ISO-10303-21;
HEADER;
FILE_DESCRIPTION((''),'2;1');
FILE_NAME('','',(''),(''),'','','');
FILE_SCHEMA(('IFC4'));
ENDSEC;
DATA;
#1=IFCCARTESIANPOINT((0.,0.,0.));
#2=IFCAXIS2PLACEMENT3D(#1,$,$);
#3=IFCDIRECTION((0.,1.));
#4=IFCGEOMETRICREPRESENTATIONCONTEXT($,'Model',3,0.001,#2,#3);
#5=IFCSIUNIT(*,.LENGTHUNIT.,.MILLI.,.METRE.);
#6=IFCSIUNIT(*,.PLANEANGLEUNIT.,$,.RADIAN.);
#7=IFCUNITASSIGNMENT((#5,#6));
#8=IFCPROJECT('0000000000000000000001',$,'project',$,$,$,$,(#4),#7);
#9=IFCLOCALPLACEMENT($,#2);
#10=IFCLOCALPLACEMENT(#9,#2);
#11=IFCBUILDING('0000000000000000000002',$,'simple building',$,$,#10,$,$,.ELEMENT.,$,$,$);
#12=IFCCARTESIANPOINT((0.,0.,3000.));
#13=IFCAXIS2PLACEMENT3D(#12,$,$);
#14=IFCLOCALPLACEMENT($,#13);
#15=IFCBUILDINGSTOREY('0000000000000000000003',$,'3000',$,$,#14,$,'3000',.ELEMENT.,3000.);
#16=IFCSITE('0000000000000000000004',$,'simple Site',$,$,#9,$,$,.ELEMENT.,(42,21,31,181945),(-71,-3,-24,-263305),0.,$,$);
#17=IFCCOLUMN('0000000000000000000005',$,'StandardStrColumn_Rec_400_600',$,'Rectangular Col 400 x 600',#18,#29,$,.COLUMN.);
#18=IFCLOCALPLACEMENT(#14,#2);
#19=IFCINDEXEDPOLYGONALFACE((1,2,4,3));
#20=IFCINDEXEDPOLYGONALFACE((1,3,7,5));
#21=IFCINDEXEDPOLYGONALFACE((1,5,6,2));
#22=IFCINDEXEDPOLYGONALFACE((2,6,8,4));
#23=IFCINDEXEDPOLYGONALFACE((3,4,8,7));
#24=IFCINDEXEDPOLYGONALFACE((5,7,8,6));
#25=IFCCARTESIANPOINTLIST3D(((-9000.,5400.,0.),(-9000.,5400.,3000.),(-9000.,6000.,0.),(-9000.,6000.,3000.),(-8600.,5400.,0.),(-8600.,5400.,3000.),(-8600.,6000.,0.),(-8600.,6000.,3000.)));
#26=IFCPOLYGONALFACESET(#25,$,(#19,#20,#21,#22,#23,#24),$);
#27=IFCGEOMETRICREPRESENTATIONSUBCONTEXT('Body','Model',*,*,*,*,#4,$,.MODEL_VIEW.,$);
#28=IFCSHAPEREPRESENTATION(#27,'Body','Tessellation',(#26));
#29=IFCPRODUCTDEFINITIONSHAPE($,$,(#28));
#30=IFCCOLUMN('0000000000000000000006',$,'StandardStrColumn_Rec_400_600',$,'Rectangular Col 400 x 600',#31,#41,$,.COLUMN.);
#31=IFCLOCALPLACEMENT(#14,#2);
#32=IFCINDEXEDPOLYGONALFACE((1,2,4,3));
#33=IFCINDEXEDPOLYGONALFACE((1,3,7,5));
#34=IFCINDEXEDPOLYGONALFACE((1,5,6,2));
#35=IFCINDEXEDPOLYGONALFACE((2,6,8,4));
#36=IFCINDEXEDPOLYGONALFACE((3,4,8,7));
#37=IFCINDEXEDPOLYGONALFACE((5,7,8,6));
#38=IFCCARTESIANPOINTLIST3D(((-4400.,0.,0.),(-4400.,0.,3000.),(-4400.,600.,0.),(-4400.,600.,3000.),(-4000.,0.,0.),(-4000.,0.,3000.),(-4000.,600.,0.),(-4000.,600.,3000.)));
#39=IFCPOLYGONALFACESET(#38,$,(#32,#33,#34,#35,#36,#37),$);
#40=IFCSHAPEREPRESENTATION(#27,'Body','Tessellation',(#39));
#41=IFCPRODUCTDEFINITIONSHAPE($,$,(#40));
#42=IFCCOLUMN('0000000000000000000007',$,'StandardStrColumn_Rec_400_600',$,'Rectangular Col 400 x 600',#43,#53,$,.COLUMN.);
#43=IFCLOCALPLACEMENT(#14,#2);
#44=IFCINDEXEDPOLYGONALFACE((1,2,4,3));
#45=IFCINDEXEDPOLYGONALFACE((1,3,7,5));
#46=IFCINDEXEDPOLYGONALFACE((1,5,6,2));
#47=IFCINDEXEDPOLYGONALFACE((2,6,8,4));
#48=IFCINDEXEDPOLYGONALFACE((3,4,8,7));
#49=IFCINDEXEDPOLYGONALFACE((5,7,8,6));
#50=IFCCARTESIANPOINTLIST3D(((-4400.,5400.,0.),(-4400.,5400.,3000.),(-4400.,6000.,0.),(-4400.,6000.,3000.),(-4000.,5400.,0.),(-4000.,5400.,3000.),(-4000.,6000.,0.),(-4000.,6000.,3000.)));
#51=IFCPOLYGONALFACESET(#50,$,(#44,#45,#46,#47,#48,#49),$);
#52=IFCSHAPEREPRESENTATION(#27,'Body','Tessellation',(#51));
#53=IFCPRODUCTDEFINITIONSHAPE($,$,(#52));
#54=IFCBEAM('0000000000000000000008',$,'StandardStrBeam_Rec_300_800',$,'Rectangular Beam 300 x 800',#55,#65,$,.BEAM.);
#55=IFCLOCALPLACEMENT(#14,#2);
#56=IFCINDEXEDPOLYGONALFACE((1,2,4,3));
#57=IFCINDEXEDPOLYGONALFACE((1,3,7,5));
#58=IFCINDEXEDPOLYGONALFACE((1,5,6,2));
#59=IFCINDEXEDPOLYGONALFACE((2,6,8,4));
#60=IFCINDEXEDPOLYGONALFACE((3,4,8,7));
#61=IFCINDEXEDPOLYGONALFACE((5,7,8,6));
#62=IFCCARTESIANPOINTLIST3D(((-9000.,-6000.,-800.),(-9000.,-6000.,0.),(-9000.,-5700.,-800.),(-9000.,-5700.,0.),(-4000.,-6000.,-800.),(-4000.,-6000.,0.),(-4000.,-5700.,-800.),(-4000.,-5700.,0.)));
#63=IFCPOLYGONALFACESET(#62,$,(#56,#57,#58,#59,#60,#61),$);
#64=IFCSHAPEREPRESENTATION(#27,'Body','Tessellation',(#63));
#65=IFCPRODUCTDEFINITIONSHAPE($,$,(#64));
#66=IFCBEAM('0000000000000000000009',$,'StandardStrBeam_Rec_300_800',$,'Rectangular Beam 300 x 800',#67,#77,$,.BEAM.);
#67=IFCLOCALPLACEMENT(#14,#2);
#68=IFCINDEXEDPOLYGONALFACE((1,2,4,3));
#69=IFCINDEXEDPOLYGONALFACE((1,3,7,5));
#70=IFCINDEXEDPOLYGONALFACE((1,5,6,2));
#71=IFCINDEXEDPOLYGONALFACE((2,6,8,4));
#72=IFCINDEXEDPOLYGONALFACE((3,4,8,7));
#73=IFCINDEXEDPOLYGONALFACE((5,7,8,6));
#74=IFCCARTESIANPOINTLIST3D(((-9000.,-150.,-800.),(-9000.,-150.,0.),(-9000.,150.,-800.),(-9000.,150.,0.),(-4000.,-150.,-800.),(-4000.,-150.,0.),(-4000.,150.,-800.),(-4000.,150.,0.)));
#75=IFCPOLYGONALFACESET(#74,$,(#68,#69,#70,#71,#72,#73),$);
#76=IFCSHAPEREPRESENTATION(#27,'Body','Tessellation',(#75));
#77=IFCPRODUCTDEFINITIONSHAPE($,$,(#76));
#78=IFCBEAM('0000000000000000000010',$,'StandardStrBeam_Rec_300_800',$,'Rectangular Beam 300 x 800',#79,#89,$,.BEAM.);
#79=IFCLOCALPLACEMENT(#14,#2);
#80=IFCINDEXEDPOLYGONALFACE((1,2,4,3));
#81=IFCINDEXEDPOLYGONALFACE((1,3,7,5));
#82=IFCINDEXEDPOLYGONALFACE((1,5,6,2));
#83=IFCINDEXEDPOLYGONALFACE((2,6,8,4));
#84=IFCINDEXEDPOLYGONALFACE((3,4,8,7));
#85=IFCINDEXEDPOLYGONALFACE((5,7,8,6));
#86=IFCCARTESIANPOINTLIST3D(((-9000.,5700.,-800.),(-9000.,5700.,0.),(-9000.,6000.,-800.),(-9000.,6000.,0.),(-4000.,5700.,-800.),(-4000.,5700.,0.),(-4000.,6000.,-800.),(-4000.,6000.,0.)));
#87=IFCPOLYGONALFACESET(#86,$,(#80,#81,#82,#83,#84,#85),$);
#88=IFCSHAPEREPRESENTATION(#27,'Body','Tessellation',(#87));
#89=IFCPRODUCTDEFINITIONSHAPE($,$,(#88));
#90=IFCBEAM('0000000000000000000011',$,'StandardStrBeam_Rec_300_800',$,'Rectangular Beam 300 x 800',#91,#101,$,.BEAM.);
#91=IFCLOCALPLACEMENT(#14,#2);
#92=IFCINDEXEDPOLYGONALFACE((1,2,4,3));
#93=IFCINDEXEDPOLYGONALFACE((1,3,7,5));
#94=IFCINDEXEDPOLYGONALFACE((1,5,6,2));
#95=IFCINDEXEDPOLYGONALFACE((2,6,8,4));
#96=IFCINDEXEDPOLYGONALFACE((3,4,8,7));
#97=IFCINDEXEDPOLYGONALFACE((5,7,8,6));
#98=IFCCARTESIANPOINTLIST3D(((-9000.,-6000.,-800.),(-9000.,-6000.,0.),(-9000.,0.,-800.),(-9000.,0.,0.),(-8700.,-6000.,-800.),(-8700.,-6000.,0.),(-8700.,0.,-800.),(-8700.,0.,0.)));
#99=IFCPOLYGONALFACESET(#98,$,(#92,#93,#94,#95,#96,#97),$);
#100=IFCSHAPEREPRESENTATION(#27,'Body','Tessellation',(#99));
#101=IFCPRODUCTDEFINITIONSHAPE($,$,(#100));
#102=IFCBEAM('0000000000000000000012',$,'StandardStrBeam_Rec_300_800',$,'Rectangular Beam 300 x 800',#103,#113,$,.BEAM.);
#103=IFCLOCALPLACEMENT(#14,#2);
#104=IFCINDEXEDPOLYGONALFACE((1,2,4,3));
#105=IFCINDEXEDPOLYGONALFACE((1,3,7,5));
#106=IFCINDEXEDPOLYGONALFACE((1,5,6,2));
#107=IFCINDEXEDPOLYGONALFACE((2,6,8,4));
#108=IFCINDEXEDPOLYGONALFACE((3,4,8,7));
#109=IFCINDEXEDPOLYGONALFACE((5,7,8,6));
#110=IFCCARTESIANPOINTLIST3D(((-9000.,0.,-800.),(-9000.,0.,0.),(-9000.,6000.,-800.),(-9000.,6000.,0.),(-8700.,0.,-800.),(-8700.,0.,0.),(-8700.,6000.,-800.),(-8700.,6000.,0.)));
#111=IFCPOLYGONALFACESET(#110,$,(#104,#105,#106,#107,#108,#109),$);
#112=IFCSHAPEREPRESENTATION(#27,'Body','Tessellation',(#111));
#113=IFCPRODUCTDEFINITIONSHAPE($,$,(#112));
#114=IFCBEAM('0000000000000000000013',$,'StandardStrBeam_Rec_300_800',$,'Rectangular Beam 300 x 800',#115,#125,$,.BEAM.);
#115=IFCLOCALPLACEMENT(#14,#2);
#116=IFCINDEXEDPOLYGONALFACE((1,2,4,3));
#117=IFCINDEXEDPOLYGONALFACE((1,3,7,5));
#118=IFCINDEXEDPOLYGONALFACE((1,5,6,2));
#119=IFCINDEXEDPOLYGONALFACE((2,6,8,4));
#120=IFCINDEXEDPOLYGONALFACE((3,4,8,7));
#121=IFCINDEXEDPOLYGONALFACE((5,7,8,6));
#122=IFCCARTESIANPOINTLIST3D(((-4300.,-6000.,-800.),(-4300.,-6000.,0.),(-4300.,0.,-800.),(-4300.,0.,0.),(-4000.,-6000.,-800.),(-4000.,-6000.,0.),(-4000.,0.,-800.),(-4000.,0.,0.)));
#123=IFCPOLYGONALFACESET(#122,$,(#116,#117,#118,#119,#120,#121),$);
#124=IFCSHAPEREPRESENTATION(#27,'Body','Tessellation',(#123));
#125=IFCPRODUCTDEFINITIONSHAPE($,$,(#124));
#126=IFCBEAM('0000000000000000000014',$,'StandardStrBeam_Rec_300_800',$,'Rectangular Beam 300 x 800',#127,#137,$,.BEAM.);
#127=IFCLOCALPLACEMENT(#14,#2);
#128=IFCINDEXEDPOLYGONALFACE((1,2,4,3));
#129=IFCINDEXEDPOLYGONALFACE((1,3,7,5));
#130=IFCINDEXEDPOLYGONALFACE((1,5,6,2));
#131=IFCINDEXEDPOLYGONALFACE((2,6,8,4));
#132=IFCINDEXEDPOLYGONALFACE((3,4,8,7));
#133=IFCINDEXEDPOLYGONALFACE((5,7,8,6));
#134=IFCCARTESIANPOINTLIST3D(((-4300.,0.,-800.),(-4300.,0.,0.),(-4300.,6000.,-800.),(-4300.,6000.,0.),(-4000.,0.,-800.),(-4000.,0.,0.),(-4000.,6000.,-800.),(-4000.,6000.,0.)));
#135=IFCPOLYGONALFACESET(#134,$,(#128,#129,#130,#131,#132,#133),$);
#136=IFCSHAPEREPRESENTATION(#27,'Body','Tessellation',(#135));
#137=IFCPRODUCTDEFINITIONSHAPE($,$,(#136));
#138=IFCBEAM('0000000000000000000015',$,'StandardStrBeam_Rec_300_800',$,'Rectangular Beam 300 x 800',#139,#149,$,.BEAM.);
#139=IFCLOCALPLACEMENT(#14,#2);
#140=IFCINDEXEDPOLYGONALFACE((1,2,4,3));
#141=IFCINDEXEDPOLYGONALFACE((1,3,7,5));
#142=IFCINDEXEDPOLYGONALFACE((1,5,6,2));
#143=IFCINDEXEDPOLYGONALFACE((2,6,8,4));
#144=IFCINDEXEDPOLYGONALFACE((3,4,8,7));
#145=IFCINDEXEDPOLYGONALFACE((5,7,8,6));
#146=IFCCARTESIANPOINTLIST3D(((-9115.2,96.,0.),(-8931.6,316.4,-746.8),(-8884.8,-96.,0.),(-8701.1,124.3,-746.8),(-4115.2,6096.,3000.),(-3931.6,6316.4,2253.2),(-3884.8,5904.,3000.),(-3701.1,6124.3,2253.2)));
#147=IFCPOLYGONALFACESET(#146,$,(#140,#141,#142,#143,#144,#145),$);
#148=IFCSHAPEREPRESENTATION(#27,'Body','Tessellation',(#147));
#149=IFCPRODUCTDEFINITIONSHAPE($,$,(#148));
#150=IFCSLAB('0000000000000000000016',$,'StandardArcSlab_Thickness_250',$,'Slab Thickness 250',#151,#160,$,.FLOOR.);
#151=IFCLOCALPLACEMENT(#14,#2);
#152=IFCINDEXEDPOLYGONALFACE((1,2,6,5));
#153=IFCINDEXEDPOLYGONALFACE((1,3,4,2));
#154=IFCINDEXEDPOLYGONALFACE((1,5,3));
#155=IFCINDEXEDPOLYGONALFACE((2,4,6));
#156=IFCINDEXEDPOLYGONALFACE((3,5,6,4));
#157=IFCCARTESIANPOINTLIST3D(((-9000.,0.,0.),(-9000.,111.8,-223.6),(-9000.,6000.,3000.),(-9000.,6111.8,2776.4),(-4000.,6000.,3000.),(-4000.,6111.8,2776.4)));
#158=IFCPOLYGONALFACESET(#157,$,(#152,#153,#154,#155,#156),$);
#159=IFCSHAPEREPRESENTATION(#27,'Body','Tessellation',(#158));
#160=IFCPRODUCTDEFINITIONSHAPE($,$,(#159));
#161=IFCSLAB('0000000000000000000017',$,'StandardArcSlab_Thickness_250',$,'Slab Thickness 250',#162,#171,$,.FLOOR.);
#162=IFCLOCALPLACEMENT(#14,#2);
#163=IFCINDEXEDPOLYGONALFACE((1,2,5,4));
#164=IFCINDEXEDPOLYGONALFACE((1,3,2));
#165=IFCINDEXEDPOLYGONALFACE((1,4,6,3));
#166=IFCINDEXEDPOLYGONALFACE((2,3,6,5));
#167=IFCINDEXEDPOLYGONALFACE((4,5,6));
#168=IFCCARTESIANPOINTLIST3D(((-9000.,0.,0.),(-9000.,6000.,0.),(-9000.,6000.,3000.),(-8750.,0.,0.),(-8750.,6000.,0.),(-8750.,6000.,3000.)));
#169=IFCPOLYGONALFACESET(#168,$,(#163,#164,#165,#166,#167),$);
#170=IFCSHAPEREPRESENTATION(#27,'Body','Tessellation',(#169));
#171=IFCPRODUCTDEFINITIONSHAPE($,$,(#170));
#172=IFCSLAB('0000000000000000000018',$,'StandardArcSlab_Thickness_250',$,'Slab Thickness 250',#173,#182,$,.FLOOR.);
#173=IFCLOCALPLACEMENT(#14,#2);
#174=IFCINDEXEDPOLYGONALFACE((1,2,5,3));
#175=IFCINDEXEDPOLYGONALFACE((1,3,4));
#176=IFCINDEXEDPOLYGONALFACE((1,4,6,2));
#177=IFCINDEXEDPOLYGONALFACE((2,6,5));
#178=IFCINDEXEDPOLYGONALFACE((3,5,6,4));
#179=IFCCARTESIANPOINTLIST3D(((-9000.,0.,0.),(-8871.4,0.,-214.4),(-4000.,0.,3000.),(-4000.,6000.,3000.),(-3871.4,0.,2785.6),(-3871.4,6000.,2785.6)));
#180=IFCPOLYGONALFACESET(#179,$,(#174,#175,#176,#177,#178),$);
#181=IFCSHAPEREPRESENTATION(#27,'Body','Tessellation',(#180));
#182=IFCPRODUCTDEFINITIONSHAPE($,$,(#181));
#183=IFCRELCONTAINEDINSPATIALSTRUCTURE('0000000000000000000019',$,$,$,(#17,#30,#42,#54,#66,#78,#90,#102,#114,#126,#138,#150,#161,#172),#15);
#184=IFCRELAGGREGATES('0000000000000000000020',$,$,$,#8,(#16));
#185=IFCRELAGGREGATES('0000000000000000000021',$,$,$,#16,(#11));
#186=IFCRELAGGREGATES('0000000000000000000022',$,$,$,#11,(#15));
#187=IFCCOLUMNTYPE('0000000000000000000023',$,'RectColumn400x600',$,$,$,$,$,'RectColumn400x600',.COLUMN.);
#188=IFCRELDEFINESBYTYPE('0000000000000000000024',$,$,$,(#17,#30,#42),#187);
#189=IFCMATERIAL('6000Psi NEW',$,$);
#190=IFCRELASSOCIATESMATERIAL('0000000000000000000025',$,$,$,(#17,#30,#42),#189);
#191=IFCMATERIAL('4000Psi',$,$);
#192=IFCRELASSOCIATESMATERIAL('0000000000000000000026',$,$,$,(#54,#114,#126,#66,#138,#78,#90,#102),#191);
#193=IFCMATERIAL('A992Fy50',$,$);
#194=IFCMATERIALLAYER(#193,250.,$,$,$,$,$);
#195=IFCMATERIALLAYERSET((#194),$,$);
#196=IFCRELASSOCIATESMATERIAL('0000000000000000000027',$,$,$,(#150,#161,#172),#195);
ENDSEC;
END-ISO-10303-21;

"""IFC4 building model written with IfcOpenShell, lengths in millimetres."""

from ifc_helpers import new_model, si_unit, direction, frame, origin, origin_with_axes, origin_2d_with_axis, place, context, subcontext, project, spatial, polyline, rectangle, outline, extrude, material, layer, layer_set, layer_usage, material_profile, profile_set, profile_usage, type_object, element, save


model = new_model("IFC4")

# Units and contexts
model_context = context("Model", 3, precision=0.001, world=origin(), true_north=direction((0.0, 1.0)))
body_context = subcontext(model_context, "Body", "Model", "MODEL_VIEW")
ifc_project = project(units=[si_unit("LENGTHUNIT", "METRE", prefix="MILLI"), si_unit("PLANEANGLEUNIT", "RADIAN")], contexts=[model_context])

# Site, building, storey
site_placement = place(None, origin())
site = spatial("IfcSite", under=ifc_project, at=site_placement, Name="simple Site", CompositionType="ELEMENT", RefLatitude=(42, 21, 31, 181945), RefLongitude=(-71, -3, -24, -263305), RefElevation=0.0)
building_placement = place(site_placement, origin())
building = spatial("IfcBuilding", under=site, at=building_placement, Name="simple building", CompositionType="ELEMENT")
storey_placement = place(None, frame((0.0, 0.0, 3000.0)))
storey = spatial("IfcBuildingStorey", under=building, at=storey_placement, Name="3000", LongName="3000", CompositionType="ELEMENT", Elevation=3000.0)

# Columns
ifc_material_1 = material(Name="6000Psi NEW")
ifc_material_profile_1 = material_profile(ifc_material_1, rectangle(XDim=400.0, YDim=600.0, at=origin_2d_with_axis()))
ifc_profile_set_1 = profile_set([ifc_material_profile_1])
ifc_profile_usage_1 = profile_usage(ifc_profile_set_1, cardinal=1)
column_type = type_object("IfcColumnType", Name="RectColumn400x600", ElementType="RectColumn400x600", PredefinedType="COLUMN")
column_1_placement = place(None, frame((-8800.0, 5700.0, 3000.0), z_axis=(0.0, 0.0, 1.0), x_axis=(1.0, 0.0, 0.0)))
element("IfcColumn", 1, at=column_1_placement, inside=storey, type_object=column_type, material=ifc_profile_usage_1, Name="StandardStrColumn_Rec_400_600", ObjectType="Rectangular Col 400 x 600", PredefinedType="COLUMN", context=body_context, shape_type="SweptSolid", body=[
    extrude(rectangle(XDim=400.0, YDim=600.0, at=origin_2d_with_axis()), origin_with_axes(), (0.0, 0.0, 1.0), 3000.0),
])
ifc_profile_usage_2 = profile_usage(ifc_profile_set_1, cardinal=9)
column_2_placement = place(None, frame((-4200.0, 300.0, 3000.0), z_axis=(0.0, 0.0, 1.0), x_axis=(1.0, 0.0, 0.0)))
element("IfcColumn", 2, at=column_2_placement, inside=storey, type_object=column_type, material=ifc_profile_usage_2, Name="StandardStrColumn_Rec_400_600", ObjectType="Rectangular Col 400 x 600", PredefinedType="COLUMN", context=body_context, shape_type="SweptSolid", body=[
    extrude(rectangle(XDim=400.0, YDim=600.0, at=origin_2d_with_axis()), origin_with_axes(), (0.0, 0.0, 1.0), 3000.0),
])
ifc_profile_usage_3 = profile_usage(ifc_profile_set_1, cardinal=3)
column_3_placement = place(None, frame((-4200.0, 5700.0, 3000.0), z_axis=(0.0, 0.0, 1.0), x_axis=(1.0, 0.0, 0.0)))
element("IfcColumn", 3, at=column_3_placement, inside=storey, type_object=column_type, material=ifc_profile_usage_3, Name="StandardStrColumn_Rec_400_600", ObjectType="Rectangular Col 400 x 600", PredefinedType="COLUMN", context=body_context, shape_type="SweptSolid", body=[
    extrude(rectangle(XDim=400.0, YDim=600.0, at=origin_2d_with_axis()), origin_with_axes(), (0.0, 0.0, 1.0), 3000.0),
])

# Beams
ifc_material_2 = material(Name="4000Psi")
ifc_material_profile_2 = material_profile(ifc_material_2, rectangle(XDim=300.0, YDim=800.0, at=origin_2d_with_axis()))
ifc_profile_set_2 = profile_set([ifc_material_profile_2])
ifc_profile_usage_4 = profile_usage(ifc_profile_set_2, cardinal=9)
beam_1_placement = place(None, frame((-9000.0, -5850.0, 2600.0), z_axis=(1.0, 0.0, 0.0), x_axis=(0.0, -1.0, 0.0)))
element("IfcBeam", 4, at=beam_1_placement, inside=storey, material=ifc_profile_usage_4, Name="StandardStrBeam_Rec_300_800", ObjectType="Rectangular Beam 300 x 800", PredefinedType="BEAM", context=body_context, shape_type="SweptSolid", body=[
    extrude(rectangle(XDim=300.0, YDim=800.0, at=origin_2d_with_axis()), origin_with_axes(), (0.0, 0.0, 1.0), 5000.0),
])
ifc_profile_usage_5 = profile_usage(ifc_profile_set_2, cardinal=8)
beam_2_placement = place(None, frame((-9000.0, 0.0, 2600.0), z_axis=(1.0, 0.0, 0.0), x_axis=(0.0, -1.0, 0.0)))
element("IfcBeam", 5, at=beam_2_placement, inside=storey, material=ifc_profile_usage_5, Name="StandardStrBeam_Rec_300_800", ObjectType="Rectangular Beam 300 x 800", PredefinedType="BEAM", context=body_context, shape_type="SweptSolid", body=[
    extrude(rectangle(XDim=300.0, YDim=800.0, at=origin_2d_with_axis()), origin_with_axes(), (0.0, 0.0, 1.0), 5000.0),
])
ifc_profile_usage_6 = profile_usage(ifc_profile_set_2, cardinal=7)
beam_3_placement = place(None, frame((-9000.0, 5850.0, 2600.0), z_axis=(1.0, 0.0, 0.0), x_axis=(0.0, -1.0, 0.0)))
element("IfcBeam", 6, at=beam_3_placement, inside=storey, material=ifc_profile_usage_6, Name="StandardStrBeam_Rec_300_800", ObjectType="Rectangular Beam 300 x 800", PredefinedType="BEAM", context=body_context, shape_type="SweptSolid", body=[
    extrude(rectangle(XDim=300.0, YDim=800.0, at=origin_2d_with_axis()), origin_with_axes(), (0.0, 0.0, 1.0), 5000.0),
])
for number, where, z_axis, x_axis, name in (
    (7, (-8850.0, -6000.0, 2600.0), (0.0, 1.0, 0.0), (1.0, 0.0, 0.0), "StandardStrBeam_Rec_300_800"),
    (8, (-8850.0, 0.0, 2600.0), (0.0, 1.0, 0.0), (1.0, 0.0, 0.0), "StandardStrBeam_Rec_300_800"),
):
    element("IfcBeam", number, at=place(None, frame(where, z_axis=z_axis, x_axis=x_axis)), inside=storey, material=ifc_profile_usage_6, Name=name, ObjectType="Rectangular Beam 300 x 800", PredefinedType="BEAM", context=body_context, shape_type="SweptSolid", body=[
        extrude(rectangle(XDim=300.0, YDim=800.0, at=origin_2d_with_axis()), origin_with_axes(), (0.0, 0.0, 1.0), 6000.0),
    ])
for number, where, z_axis, x_axis, name in (
    (9, (-4150.0, -6000.0, 2600.0), (0.0, 1.0, 0.0), (1.0, 0.0, 0.0), "StandardStrBeam_Rec_300_800"),
    (10, (-4150.0, 0.0, 2600.0), (0.0, 1.0, 0.0), (1.0, 0.0, 0.0), "StandardStrBeam_Rec_300_800"),
):
    element("IfcBeam", number, at=place(None, frame(where, z_axis=z_axis, x_axis=x_axis)), inside=storey, material=ifc_profile_usage_4, Name=name, ObjectType="Rectangular Beam 300 x 800", PredefinedType="BEAM", context=body_context, shape_type="SweptSolid", body=[
        extrude(rectangle(XDim=300.0, YDim=800.0, at=origin_2d_with_axis()), origin_with_axes(), (0.0, 0.0, 1.0), 6000.0),
    ])
beam_4_placement = place(None, frame((-8908.2, 110.2, 2626.6), z_axis=(0.597614, 0.717137, 0.358569), x_axis=(0.768221, -0.640184, 0.0)))
element("IfcBeam", 11, at=beam_4_placement, inside=storey, material=ifc_profile_usage_5, Name="StandardStrBeam_Rec_300_800", ObjectType="Rectangular Beam 300 x 800", PredefinedType="BEAM", context=body_context, shape_type="SweptSolid", body=[
    extrude(rectangle(XDim=300.0, YDim=800.0, at=origin_2d_with_axis()), origin_with_axes(), (0.0, 0.0, 1.0), 8366.6),
])

# Slabs
ifc_material_3 = material(Name="A992Fy50")
ifc_layer_1 = layer(ifc_material_3, 250.0)
ifc_layer_set_1 = layer_set([ifc_layer_1])
ifc_layer_usage_1 = layer_usage(ifc_layer_set_1, "AXIS3", "POSITIVE", -250.0)
slab_1_placement = place(None, frame((-9000.0, 6111.8, 5776.4), z_axis=(0.0, -0.447214, 0.894427), x_axis=(0.0, -0.894427, -0.447214)))
element("IfcSlab", 12, at=slab_1_placement, inside=storey, material=ifc_layer_usage_1, Name="StandardArcSlab_Thickness_250", ObjectType="Slab Thickness 250", PredefinedType="FLOOR", context=body_context, shape_type="SweptSolid", body=[
    extrude(outline(polyline([(0.0, 0.0), (6708.2, 0.0), (0.0, 5000.0), (0.0, 0.0)])), origin_with_axes(), (0.0, 0.0, 1.0), 250.0),
])
slab_2_placement = place(None, frame((-8750.0, 6000.0, 3000.0), z_axis=(-1.0, 0.0, 0.0), x_axis=(0.0, -1.0, 0.0)))
element("IfcSlab", 13, at=slab_2_placement, inside=storey, material=ifc_layer_usage_1, Name="StandardArcSlab_Thickness_250", ObjectType="Slab Thickness 250", PredefinedType="FLOOR", context=body_context, shape_type="SweptSolid", body=[
    extrude(outline(polyline([(0.0, 0.0), (6000.0, 0.0), (0.0, 3000.0), (0.0, 0.0)])), origin_with_axes(), (0.0, 0.0, 1.0), 250.0),
])
slab_3_placement = place(None, frame((-8871.4, 0.0, 2785.6), z_axis=(-0.514496, 0.0, 0.857493), x_axis=(0.857493, 0.0, 0.514496)))
element("IfcSlab", 14, at=slab_3_placement, inside=storey, material=ifc_layer_usage_1, Name="StandardArcSlab_Thickness_250", ObjectType="Slab Thickness 250", PredefinedType="FLOOR", context=body_context, shape_type="SweptSolid", body=[
    extrude(outline(polyline([(0.0, 0.0), (5831.0, 0.0), (5831.0, 6000.0), (0.0, 0.0)])), origin_with_axes(), (0.0, 0.0, 1.0), 250.0),
])

save(model, "model.ifc")
